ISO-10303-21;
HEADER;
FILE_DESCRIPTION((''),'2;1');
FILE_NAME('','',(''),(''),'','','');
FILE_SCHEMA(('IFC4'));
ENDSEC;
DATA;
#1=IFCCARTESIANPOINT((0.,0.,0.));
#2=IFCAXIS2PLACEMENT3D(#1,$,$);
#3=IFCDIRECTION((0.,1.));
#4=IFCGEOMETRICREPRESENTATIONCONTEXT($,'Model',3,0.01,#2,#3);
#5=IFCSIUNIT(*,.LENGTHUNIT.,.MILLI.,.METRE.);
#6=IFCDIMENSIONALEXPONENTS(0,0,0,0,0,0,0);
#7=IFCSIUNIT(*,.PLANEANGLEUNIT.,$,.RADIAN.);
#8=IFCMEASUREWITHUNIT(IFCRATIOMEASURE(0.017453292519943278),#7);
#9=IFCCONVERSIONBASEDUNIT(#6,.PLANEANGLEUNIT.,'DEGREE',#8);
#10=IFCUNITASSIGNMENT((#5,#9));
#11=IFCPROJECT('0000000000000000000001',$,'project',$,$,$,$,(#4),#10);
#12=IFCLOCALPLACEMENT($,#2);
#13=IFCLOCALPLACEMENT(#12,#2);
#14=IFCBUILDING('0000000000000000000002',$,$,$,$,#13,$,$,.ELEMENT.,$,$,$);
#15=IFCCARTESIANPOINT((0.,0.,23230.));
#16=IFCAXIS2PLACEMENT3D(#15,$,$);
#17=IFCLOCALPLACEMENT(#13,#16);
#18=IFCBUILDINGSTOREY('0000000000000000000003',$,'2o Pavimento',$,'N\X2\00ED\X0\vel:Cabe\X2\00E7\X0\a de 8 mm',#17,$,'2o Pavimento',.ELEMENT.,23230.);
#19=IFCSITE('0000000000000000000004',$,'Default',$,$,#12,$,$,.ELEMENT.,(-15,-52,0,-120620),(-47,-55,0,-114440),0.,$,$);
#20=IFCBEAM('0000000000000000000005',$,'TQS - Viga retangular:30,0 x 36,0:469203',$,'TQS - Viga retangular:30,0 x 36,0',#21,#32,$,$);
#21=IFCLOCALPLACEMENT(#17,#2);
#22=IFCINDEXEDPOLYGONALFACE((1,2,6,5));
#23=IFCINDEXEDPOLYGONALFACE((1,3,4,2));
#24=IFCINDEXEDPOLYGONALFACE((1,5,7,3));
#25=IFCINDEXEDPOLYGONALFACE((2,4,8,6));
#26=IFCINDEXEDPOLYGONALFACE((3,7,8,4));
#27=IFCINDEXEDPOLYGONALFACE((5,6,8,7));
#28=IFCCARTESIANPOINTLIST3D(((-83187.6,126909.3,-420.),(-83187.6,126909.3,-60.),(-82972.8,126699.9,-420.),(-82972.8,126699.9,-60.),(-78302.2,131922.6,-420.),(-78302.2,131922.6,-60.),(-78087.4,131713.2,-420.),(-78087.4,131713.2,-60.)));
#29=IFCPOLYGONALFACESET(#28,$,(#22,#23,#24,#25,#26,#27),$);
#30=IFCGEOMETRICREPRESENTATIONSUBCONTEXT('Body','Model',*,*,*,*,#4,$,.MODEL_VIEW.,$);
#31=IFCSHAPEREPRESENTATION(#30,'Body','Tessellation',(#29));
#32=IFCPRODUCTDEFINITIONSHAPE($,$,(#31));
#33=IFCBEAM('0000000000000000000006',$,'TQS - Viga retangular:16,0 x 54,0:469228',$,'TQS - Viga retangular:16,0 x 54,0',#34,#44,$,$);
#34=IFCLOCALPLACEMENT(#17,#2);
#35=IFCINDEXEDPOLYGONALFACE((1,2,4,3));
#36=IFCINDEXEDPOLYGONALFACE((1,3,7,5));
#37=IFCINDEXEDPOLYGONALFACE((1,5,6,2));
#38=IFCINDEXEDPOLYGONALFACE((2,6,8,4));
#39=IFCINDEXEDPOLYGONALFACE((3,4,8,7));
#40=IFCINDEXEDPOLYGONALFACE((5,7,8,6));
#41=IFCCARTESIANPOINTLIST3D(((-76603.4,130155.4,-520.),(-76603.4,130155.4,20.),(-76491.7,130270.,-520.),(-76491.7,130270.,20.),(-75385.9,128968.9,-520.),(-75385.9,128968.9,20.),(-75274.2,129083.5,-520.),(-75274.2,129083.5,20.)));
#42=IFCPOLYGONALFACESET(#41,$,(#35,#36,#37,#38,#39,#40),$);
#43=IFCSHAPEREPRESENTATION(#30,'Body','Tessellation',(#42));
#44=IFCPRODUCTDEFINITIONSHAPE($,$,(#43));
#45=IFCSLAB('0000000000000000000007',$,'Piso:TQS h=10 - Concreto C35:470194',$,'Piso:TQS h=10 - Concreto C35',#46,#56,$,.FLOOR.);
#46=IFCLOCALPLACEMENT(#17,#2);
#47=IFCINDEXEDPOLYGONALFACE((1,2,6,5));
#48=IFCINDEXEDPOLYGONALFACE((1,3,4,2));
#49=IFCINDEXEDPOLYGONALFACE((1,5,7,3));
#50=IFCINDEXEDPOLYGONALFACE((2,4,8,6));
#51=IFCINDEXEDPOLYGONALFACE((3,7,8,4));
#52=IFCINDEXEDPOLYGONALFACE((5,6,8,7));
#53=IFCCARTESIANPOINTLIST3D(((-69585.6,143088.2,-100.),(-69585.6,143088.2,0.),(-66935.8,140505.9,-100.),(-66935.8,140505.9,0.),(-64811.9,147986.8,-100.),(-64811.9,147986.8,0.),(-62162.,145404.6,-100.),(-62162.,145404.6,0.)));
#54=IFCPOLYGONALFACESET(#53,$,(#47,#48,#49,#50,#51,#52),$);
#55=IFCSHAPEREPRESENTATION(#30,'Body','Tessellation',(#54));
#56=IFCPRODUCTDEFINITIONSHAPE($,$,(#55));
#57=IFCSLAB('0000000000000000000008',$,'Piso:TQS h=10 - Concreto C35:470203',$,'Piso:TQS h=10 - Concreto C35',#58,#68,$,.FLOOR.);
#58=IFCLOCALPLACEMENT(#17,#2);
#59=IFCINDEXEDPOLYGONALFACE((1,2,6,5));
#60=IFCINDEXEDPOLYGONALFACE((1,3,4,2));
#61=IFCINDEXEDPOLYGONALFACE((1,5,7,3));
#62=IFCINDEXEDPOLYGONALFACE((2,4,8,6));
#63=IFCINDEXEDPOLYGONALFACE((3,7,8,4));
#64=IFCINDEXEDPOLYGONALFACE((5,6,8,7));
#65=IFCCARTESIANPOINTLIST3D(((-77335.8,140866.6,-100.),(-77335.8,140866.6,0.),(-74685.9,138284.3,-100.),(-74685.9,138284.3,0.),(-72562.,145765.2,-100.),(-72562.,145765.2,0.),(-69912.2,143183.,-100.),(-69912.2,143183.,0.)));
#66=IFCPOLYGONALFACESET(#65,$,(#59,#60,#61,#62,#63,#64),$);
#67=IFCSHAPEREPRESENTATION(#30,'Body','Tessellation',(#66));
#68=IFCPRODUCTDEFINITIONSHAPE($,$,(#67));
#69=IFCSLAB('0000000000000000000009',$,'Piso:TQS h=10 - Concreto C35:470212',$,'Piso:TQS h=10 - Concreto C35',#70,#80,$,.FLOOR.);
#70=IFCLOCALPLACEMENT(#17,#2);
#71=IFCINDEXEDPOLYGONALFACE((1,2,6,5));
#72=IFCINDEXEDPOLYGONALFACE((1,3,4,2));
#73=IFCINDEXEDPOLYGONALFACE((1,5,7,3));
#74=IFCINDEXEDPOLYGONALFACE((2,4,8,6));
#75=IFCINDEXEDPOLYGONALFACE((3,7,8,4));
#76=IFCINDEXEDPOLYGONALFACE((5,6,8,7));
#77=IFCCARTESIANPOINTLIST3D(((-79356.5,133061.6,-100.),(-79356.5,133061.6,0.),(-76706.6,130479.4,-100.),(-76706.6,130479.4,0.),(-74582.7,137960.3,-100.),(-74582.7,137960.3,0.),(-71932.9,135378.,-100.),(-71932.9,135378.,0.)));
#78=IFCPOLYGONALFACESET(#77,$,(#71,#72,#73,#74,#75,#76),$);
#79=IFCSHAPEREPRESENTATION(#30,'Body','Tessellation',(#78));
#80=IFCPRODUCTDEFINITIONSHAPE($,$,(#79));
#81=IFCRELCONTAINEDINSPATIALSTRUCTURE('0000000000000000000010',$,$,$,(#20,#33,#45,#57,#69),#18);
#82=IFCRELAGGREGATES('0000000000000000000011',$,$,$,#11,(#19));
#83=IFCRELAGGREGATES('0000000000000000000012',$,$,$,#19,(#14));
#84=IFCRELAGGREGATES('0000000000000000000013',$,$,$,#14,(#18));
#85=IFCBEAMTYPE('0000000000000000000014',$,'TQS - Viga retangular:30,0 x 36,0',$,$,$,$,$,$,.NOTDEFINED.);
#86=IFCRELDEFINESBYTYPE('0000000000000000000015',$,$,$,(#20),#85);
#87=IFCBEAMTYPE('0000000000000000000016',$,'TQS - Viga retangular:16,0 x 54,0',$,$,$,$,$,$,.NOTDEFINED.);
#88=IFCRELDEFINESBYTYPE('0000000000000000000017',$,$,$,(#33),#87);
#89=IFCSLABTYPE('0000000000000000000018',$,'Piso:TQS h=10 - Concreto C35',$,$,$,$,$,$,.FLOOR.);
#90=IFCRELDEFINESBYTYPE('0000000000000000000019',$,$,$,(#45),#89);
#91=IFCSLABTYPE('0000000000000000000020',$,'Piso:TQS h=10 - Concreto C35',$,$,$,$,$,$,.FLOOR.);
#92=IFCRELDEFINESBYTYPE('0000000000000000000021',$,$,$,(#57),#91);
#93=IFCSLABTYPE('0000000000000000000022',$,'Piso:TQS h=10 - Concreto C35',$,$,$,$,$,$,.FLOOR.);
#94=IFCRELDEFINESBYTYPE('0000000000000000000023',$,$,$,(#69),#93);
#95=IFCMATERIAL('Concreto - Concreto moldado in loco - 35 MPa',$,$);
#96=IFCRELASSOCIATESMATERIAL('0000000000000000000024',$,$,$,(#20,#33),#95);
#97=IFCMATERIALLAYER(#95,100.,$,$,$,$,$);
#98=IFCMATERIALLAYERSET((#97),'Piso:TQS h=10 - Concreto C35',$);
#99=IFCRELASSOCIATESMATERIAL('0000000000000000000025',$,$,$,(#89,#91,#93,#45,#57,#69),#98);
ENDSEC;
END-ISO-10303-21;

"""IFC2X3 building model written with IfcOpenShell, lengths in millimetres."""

from ifc_helpers import new_model, entity, si_unit, converted_unit, direction, frame, frame_2d, origin, place, context, subcontext, project, spatial, rectangle, extrude, material, layer, layer_set, layer_usage, type_object, element, save


model = new_model("IFC2X3")

# Units and contexts
model_context = context("Model", 3, precision=0.01, world=origin(), true_north=direction((0.0, 1.0)))
body_context = subcontext(model_context, "Body", "Model", "MODEL_VIEW")
ifc_project = project(units=[si_unit("LENGTHUNIT", "METRE", prefix="MILLI"), converted_unit("PLANEANGLEUNIT", "DEGREE", entity("IfcRatioMeasure", 0.017453292519943278), si_unit("PLANEANGLEUNIT", "RADIAN"), dimensions=[0, 0, 0, 0, 0, 0, 0])], contexts=[model_context])

# Site, building, storey
site_placement = place(None, origin())
site = spatial("IfcSite", under=ifc_project, at=site_placement, Name="Default", CompositionType="ELEMENT", RefLatitude=(-15, -52, 0, -120620), RefLongitude=(-47, -55, 0, -114440), RefElevation=0.0)
building_placement = place(site_placement, origin())
building = spatial("IfcBuilding", under=site, at=building_placement, CompositionType="ELEMENT")
storey_placement = place(building_placement, frame((0.0, 0.0, 23230.0)))
storey = spatial("IfcBuildingStorey", under=building, at=storey_placement, Name="2o Pavimento", ObjectType="Nível:Cabeça de 8 mm", LongName="2o Pavimento", CompositionType="ELEMENT", Elevation=23230.0)

# Beams
ifc_material = material(Name="Concreto - Concreto moldado in loco - 35 MPa")
beam_type_1 = type_object("IfcBeamType", Name="TQS - Viga retangular:30,0 x 36,0", PredefinedType="NOTDEFINED")
beam_1_placement = place(storey_placement, frame((-83080.2, 126804.6, -60.0), z_axis=(0.0, 0.0, 1.0), x_axis=(0.697915, 0.71618, 0.0)))
element("IfcBeam", 1, at=beam_1_placement, inside=storey, type_object=beam_type_1, material=ifc_material, Name="TQS - Viga retangular:30,0 x 36,0:469203", ObjectType="TQS - Viga retangular:30,0 x 36,0", context=body_context, shape_type="SweptSolid", body=[
    extrude(rectangle(XDim=360.0, YDim=300.0, at=frame_2d((0.0, 0.0), x_axis=(1.0, 0.0))), frame((0.0, 0.0, -180.0), z_axis=(1.0, 0.0, 0.0), x_axis=(0.0, 0.0, -1.0)), (0.0, 0.0, 1.0), 7000.0),
])
beam_type_2 = type_object("IfcBeamType", Name="TQS - Viga retangular:16,0 x 54,0", PredefinedType="NOTDEFINED")
beam_2_placement = place(storey_placement, frame((-75330.1, 129026.2, 20.0), z_axis=(0.0, 0.0, 1.0), x_axis=(-0.71618, 0.697915, 0.0)))
element("IfcBeam", 2, at=beam_2_placement, inside=storey, type_object=beam_type_2, material=ifc_material, Name="TQS - Viga retangular:16,0 x 54,0:469228", ObjectType="TQS - Viga retangular:16,0 x 54,0", context=body_context, shape_type="SweptSolid", body=[
    extrude(rectangle(XDim=540.0, YDim=160.0, at=frame_2d((0.0, 0.0), x_axis=(1.0, 0.0))), frame((0.0, 0.0, -270.0), z_axis=(1.0, 0.0, 0.0), x_axis=(0.0, 0.0, -1.0)), (0.0, 0.0, 1.0), 1700.0),
])

# Slabs
ifc_layer = layer(ifc_material, 100.0)
ifc_layer_set = layer_set([ifc_layer], Name="Piso:TQS h=10 - Concreto C35")
ifc_layer_usage_1 = layer_usage(ifc_layer_set, "AXIS3", "POSITIVE", 0.0)
slab_type_1 = type_object("IfcSlabType", Name="Piso:TQS h=10 - Concreto C35", PredefinedType="FLOOR", material=ifc_layer_set)
slab_1_placement = place(storey_placement, origin())
element("IfcSlab", 3, at=slab_1_placement, inside=storey, type_object=slab_type_1, material=ifc_layer_usage_1, Name="Piso:TQS h=10 - Concreto C35:470194", ObjectType="Piso:TQS h=10 - Concreto C35", PredefinedType="FLOOR", context=body_context, shape_type="SweptSolid", body=[
    extrude(rectangle(XDim=6840.0, YDim=3700.0, at=frame_2d((0.0, 0.0), x_axis=(1.0, 0.0))), frame((-65873.8, 144246.4, 0.0), z_axis=(0.0, 0.0, -1.0), x_axis=(-0.697915, -0.71618, 0.0)), (0.0, 0.0, 1.0), 100.0),
])
ifc_layer_usage_2 = layer_usage(ifc_layer_set, "AXIS3", "POSITIVE", 0.0)
slab_type_2 = type_object("IfcSlabType", Name="Piso:TQS h=10 - Concreto C35", PredefinedType="FLOOR", material=ifc_layer_set)
slab_2_placement = place(storey_placement, origin())
element("IfcSlab", 4, at=slab_2_placement, inside=storey, type_object=slab_type_2, material=ifc_layer_usage_2, Name="Piso:TQS h=10 - Concreto C35:470203", ObjectType="Piso:TQS h=10 - Concreto C35", PredefinedType="FLOOR", context=body_context, shape_type="SweptSolid", body=[
    extrude(rectangle(XDim=3700.0, YDim=6840.0, at=frame_2d((0.0, 0.0), x_axis=(1.0, 0.0))), frame((-73624.0, 142024.8, 0.0), z_axis=(0.0, 0.0, -1.0), x_axis=(0.71618, -0.697915, 0.0)), (0.0, 0.0, 1.0), 100.0),
])
ifc_layer_usage_3 = layer_usage(ifc_layer_set, "AXIS3", "POSITIVE", 0.0)
slab_type_3 = type_object("IfcSlabType", Name="Piso:TQS h=10 - Concreto C35", PredefinedType="FLOOR", material=ifc_layer_set)
slab_3_placement = place(storey_placement, origin())
element("IfcSlab", 5, at=slab_3_placement, inside=storey, type_object=slab_type_3, material=ifc_layer_usage_3, Name="Piso:TQS h=10 - Concreto C35:470212", ObjectType="Piso:TQS h=10 - Concreto C35", PredefinedType="FLOOR", context=body_context, shape_type="SweptSolid", body=[
    extrude(rectangle(XDim=6840.0, YDim=3700.0, at=frame_2d((0.0, 0.0), x_axis=(1.0, 0.0))), frame((-75644.7, 134219.8, 0.0), z_axis=(0.0, 0.0, -1.0), x_axis=(-0.697915, -0.71618, 0.0)), (0.0, 0.0, 1.0), 100.0),
])

save(model, "model.ifc")
